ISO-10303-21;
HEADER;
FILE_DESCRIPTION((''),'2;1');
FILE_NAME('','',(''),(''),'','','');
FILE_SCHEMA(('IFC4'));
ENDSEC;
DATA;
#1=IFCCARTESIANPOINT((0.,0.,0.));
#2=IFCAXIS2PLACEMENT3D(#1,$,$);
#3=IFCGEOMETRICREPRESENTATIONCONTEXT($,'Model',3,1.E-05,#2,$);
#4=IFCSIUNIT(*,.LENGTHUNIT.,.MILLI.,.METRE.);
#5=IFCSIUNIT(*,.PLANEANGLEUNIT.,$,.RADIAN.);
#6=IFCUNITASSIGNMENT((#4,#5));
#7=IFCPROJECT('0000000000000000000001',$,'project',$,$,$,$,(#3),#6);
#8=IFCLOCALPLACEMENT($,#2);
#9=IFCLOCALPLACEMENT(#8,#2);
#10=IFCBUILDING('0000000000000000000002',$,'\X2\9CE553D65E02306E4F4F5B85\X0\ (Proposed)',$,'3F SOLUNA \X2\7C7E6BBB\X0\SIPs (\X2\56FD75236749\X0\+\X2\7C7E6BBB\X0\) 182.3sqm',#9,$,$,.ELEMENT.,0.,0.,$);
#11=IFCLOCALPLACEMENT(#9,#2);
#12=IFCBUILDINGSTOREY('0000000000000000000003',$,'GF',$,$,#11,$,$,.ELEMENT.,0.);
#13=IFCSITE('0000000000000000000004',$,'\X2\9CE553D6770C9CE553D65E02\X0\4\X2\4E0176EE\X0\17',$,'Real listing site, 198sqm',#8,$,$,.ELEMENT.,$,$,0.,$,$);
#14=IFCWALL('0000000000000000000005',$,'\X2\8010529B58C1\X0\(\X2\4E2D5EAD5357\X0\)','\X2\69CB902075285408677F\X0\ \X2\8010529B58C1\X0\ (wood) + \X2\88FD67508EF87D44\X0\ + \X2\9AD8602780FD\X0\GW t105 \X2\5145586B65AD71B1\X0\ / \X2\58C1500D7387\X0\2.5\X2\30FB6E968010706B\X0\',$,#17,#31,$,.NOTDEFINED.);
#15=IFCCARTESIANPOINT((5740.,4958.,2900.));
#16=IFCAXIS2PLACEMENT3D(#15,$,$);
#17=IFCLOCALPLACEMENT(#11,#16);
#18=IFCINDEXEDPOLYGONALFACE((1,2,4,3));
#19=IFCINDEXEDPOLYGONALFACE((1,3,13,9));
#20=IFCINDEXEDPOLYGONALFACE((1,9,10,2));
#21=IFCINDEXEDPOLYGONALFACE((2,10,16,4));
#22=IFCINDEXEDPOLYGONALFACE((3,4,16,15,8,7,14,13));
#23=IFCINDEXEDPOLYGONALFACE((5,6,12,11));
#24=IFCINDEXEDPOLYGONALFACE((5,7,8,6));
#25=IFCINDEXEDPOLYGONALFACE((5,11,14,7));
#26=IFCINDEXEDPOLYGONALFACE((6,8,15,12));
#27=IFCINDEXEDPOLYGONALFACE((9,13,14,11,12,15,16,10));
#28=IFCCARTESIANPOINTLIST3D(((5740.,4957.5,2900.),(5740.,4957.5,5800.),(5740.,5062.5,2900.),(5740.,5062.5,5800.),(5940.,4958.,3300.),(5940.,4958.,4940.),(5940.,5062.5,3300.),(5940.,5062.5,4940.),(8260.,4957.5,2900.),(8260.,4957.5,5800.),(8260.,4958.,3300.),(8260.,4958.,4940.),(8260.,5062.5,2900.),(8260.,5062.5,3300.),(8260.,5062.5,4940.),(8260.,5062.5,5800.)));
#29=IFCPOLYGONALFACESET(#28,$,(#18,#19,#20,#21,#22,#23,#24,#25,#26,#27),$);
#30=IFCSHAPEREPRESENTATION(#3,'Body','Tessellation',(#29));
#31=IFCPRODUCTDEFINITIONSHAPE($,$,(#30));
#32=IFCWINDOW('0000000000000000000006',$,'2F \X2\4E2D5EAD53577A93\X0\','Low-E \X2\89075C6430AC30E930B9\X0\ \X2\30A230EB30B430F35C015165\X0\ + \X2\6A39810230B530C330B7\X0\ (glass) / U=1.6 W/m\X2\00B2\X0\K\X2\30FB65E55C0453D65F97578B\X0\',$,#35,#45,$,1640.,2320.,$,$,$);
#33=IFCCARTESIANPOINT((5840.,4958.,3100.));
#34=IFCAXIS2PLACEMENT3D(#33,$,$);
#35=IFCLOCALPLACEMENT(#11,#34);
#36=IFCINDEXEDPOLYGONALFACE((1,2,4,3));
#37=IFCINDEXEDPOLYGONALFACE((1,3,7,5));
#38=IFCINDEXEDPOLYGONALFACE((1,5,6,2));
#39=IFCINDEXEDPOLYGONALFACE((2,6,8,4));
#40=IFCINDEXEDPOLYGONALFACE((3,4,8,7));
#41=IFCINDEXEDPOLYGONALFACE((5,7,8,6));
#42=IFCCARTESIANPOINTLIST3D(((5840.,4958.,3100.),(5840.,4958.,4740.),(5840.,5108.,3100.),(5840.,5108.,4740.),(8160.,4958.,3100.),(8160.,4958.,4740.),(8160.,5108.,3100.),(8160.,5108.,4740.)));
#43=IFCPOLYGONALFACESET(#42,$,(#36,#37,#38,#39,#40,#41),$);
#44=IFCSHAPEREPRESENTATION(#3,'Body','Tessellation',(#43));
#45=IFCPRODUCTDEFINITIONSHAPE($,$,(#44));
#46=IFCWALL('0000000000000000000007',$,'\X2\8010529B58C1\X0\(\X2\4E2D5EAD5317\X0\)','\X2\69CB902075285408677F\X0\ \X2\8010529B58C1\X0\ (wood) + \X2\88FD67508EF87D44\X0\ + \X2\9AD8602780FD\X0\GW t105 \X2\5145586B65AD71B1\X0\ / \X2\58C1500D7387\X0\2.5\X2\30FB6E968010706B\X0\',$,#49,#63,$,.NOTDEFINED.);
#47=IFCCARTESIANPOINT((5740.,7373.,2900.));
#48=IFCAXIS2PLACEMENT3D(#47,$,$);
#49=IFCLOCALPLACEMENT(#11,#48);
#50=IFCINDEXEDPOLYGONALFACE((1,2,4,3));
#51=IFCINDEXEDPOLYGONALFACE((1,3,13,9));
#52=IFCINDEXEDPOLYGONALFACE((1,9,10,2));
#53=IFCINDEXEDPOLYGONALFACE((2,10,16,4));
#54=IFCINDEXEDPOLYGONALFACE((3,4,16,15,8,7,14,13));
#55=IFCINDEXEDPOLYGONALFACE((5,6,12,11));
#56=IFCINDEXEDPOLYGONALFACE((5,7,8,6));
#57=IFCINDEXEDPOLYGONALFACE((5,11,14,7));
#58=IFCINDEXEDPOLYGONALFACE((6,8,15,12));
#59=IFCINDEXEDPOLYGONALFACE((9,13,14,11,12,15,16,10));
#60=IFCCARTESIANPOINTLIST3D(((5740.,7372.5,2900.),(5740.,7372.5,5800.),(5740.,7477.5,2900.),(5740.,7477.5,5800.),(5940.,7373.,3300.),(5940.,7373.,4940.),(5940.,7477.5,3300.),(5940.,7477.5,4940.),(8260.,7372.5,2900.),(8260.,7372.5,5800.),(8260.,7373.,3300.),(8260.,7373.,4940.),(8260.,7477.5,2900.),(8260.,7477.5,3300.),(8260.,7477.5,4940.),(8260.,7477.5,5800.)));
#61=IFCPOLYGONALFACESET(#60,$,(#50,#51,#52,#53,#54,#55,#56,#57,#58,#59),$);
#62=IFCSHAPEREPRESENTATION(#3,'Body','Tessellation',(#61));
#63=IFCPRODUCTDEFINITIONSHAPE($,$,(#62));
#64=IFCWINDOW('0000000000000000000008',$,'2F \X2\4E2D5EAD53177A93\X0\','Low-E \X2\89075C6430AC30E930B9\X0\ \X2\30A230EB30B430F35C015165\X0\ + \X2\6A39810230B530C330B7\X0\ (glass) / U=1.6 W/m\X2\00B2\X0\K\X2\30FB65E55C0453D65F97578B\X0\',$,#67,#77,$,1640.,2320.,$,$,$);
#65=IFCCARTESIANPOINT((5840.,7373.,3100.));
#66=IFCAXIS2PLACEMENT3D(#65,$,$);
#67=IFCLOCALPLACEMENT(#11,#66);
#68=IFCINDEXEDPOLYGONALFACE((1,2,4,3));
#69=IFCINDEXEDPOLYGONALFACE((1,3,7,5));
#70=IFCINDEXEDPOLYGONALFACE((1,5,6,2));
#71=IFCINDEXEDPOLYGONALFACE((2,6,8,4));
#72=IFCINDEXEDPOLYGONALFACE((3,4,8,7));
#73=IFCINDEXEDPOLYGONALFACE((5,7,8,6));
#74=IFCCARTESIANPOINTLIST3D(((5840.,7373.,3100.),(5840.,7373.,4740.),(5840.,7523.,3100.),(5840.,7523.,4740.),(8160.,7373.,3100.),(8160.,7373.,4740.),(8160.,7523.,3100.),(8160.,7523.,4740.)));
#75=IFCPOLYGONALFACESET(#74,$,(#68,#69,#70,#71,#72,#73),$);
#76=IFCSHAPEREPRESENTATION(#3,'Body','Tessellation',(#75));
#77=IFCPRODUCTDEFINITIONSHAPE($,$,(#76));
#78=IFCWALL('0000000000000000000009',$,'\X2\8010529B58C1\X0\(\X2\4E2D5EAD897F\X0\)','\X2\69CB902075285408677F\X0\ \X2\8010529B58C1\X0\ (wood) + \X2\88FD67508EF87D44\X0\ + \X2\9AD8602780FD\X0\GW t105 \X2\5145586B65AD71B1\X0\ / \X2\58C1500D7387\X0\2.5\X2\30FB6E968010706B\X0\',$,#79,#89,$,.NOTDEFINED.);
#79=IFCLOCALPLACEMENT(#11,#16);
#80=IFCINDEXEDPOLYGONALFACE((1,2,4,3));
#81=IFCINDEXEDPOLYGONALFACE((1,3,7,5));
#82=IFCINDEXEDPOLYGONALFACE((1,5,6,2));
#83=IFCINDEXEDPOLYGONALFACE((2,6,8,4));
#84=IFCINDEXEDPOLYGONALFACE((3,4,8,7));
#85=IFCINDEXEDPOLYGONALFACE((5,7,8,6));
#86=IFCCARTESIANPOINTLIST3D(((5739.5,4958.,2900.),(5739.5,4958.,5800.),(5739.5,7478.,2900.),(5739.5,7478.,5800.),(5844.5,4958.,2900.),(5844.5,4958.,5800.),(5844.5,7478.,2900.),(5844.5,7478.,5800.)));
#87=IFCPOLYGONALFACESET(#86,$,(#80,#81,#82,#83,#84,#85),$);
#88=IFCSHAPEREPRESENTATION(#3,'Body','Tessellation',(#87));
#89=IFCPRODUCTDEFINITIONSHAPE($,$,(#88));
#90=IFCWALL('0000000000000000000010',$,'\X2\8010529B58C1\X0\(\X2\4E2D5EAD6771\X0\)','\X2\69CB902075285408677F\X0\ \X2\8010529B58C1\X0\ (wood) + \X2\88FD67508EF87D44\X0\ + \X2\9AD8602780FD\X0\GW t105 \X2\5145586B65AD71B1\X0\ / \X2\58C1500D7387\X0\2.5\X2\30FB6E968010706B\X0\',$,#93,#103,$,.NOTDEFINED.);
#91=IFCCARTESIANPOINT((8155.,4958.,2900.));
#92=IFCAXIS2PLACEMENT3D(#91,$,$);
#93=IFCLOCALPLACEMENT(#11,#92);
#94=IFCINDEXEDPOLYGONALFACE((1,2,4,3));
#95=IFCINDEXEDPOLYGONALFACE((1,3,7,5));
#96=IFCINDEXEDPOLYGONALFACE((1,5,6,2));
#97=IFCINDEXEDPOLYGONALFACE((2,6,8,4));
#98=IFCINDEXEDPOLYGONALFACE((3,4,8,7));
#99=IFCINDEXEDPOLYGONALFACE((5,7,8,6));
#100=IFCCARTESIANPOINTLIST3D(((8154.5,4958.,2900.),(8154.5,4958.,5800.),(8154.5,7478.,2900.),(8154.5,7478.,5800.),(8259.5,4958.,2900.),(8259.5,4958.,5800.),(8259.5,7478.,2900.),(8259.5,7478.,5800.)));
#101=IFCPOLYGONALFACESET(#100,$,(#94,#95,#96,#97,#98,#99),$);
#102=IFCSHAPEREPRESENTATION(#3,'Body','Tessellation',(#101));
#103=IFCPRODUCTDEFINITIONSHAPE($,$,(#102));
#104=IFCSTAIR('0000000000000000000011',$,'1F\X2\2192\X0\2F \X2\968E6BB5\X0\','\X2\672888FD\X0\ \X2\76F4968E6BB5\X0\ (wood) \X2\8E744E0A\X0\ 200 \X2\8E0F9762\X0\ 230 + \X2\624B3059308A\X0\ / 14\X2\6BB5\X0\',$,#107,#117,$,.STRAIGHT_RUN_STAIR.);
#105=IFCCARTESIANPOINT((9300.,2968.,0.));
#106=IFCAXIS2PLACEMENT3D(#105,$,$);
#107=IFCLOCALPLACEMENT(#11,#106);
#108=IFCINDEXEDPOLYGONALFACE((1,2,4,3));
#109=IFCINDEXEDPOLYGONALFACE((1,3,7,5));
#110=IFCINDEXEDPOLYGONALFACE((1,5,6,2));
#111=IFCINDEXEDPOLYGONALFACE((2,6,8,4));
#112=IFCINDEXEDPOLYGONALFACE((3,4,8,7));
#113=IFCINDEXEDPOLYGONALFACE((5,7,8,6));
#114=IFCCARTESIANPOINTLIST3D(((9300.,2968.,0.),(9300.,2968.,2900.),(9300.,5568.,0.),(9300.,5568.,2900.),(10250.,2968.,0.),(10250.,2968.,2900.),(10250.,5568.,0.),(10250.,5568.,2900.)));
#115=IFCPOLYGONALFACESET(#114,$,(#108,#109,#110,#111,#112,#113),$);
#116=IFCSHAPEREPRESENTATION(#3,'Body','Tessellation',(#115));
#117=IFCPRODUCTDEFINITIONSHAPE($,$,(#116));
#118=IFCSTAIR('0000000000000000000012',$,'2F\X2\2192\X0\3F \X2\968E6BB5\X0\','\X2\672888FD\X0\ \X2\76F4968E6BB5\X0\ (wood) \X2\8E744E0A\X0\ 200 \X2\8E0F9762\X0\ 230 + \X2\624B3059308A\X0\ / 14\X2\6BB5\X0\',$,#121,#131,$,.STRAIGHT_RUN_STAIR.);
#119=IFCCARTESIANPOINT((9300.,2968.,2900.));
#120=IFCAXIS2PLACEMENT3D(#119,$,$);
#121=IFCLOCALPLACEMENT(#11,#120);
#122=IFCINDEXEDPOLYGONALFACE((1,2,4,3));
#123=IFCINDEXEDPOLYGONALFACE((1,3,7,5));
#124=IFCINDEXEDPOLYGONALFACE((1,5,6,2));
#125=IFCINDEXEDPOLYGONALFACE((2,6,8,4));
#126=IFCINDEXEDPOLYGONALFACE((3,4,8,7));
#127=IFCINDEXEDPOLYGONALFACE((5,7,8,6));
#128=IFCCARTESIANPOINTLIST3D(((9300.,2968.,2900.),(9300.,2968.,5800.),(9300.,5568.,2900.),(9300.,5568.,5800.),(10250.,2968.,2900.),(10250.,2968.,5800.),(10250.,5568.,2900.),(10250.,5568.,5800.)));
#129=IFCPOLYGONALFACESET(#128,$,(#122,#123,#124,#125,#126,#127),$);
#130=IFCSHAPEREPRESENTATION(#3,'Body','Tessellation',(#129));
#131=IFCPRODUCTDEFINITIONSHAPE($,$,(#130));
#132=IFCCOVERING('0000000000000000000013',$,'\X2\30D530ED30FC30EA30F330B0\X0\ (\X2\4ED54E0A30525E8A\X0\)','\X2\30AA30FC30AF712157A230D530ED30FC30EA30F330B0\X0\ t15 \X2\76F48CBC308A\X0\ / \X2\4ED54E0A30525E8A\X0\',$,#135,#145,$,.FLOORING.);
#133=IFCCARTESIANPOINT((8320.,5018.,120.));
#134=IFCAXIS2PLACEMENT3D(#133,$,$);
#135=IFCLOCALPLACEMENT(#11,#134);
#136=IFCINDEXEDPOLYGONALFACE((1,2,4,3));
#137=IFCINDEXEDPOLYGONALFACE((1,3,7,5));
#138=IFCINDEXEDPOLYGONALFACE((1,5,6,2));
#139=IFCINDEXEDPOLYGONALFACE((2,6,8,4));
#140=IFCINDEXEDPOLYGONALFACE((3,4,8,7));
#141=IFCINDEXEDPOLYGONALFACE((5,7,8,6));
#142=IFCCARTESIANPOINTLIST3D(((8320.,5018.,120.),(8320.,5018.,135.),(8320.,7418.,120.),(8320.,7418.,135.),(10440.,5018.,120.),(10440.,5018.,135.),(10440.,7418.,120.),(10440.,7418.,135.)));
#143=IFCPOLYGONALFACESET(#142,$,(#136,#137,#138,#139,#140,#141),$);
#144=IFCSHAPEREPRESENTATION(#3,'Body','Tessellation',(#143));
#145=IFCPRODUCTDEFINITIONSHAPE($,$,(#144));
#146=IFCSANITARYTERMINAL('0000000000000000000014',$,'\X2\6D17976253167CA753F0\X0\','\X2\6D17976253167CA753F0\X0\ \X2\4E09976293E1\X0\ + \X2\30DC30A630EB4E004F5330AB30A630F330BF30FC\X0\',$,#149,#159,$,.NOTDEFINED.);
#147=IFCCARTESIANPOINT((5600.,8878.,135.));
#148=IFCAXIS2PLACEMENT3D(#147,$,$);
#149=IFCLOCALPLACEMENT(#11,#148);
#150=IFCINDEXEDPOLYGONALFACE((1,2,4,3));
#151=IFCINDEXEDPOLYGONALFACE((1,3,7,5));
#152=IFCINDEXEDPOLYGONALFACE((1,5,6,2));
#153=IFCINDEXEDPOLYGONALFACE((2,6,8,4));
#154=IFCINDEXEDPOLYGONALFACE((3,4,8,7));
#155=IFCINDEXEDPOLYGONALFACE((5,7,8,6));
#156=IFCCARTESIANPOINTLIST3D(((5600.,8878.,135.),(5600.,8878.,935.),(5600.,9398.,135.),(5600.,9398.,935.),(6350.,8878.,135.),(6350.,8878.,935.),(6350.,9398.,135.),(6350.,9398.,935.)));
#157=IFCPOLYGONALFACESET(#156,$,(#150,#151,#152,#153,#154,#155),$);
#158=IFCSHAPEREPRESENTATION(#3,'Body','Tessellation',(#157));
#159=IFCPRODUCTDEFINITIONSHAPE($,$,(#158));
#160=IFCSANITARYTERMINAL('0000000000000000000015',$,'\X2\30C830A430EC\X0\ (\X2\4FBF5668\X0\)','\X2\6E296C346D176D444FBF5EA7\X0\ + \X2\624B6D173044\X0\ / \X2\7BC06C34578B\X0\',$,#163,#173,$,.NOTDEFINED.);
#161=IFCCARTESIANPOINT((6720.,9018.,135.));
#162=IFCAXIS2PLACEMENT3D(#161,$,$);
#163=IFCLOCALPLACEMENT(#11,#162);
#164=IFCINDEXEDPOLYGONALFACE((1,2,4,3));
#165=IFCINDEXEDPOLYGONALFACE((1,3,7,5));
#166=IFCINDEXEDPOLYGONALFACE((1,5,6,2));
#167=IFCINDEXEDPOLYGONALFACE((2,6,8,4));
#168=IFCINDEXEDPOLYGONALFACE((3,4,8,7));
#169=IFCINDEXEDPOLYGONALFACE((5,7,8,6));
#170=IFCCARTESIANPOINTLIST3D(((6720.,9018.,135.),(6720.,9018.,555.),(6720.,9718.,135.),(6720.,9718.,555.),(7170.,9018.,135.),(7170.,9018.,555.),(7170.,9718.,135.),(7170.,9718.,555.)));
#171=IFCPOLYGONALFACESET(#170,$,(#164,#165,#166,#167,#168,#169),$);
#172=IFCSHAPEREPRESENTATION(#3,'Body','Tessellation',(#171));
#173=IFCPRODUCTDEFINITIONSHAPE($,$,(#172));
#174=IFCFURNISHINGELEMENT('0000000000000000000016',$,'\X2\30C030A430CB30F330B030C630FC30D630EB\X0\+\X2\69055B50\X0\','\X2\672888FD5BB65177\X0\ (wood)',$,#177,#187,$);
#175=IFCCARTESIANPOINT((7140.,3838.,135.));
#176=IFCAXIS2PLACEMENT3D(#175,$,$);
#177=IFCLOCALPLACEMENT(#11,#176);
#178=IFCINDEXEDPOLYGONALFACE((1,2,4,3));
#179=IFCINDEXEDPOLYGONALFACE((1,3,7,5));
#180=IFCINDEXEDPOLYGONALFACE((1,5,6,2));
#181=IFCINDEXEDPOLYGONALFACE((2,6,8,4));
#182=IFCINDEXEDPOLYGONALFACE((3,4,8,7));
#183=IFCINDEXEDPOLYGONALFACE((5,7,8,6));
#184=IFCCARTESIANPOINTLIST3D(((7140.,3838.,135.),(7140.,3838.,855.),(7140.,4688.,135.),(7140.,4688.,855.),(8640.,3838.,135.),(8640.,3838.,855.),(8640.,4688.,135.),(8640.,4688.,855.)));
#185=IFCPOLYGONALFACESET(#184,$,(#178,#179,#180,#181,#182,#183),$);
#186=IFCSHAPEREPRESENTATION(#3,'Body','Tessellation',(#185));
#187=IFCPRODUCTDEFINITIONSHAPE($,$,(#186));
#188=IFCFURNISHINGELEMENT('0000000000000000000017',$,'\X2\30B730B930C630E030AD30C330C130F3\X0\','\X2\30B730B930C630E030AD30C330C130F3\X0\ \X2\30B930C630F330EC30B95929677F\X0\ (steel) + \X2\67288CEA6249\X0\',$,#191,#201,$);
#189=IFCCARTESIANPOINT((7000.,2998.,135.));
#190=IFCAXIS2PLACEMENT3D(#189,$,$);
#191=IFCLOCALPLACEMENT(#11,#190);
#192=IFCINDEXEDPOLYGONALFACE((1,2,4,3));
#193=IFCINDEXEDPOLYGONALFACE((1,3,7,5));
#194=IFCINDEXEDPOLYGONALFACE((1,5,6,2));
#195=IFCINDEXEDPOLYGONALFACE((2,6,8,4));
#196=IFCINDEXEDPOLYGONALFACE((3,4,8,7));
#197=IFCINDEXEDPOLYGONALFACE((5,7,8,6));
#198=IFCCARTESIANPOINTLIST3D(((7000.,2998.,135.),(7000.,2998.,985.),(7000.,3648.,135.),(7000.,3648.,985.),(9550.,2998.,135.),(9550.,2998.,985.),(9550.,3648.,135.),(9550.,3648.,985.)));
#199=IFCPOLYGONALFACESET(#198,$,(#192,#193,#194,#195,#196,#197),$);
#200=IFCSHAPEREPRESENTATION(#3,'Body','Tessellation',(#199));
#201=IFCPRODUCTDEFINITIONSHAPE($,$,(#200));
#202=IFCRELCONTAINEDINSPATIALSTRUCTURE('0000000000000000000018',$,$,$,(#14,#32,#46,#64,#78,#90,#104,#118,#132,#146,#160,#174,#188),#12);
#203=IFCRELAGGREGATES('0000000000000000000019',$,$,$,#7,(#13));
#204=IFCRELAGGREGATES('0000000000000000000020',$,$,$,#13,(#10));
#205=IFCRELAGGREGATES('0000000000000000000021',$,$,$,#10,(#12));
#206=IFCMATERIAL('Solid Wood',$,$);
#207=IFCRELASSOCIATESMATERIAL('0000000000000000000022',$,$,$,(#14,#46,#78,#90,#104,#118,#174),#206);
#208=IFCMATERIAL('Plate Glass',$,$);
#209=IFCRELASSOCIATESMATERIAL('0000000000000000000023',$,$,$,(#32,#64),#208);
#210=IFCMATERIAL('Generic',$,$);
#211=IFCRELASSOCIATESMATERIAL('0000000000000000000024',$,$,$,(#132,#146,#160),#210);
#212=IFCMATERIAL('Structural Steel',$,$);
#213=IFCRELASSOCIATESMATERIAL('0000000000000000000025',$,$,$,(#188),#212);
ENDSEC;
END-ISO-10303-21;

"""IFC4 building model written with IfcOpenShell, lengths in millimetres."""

from ifc_helpers import new_model, si_unit, frame, frame_2d, origin, place, context, project, spatial, rectangle, extrude, material, element, fill, save


model = new_model("IFC4")

# Units and contexts
model_context = context("Model", 3, precision=1e-05, world=origin())
ifc_project = project(units=[si_unit("LENGTHUNIT", "METRE", prefix="MILLI"), si_unit("PLANEANGLEUNIT", "RADIAN")], contexts=[model_context])

# Site, building, storey
site_placement = place(None, origin())
site = spatial("IfcSite", under=ifc_project, at=site_placement, Name="鳥取県鳥取市4丁目17", ObjectType="Real listing site, 198sqm", CompositionType="ELEMENT", RefElevation=0.0)
building_placement = place(site_placement, origin())
building = spatial("IfcBuilding", under=site, at=building_placement, Name="鳥取市の住宅 (Proposed)", ObjectType="3F SOLUNA 籾殻SIPs (国産杉+籾殻) 182.3sqm", CompositionType="ELEMENT", ElevationOfRefHeight=0.0, ElevationOfTerrain=0.0)
storey_placement = place(building_placement, origin())
storey = spatial("IfcBuildingStorey", under=building, at=storey_placement, Name="GF", CompositionType="ELEMENT", Elevation=0.0)

# Shared definitions
ifc_material_1 = material(Name="Solid Wood")

# Shared definitions
ifc_material_2 = material(Name="Plate Glass")

# Walls, openings, windows
wall_1_placement = place(storey_placement, frame((5740.0, 4958.0, 2900.0)))
wall_1 = element("IfcWall", 1, at=wall_1_placement, inside=storey, material=ifc_material_1, Name="耐力壁(中庭南)", Description="構造用合板 耐力壁 (wood) + 製材軸組 + 高性能GW t105 充填断熱 / 壁倍率2.5・準耐火", PredefinedType="NOTDEFINED", context=model_context, shape_type="SweptSolid", body=[
    extrude(rectangle(XDim=2520.0, YDim=105.0, at=frame_2d((1260.0, 52.0))), frame((5740.0, 4958.0, 2900.0)), (0.0, 0.0, 1.0), 2900.0),
])
opening_1_placement = place(storey_placement, frame((5840.0, 4958.0, 3100.0)))
opening_1 = element("IfcOpeningElement", 2, at=opening_1_placement, cuts=wall_1, PredefinedType="NOTDEFINED", context=model_context, shape_type="SweptSolid", body=[
    extrude(rectangle(XDim=2320.0, YDim=150.0, at=frame_2d((1160.0, 75.0))), frame((5840.0, 4958.0, 3100.0)), (0.0, 0.0, 1.0), 1640.0),
])
window_1_placement = place(storey_placement, frame((5840.0, 4958.0, 3100.0)))
window_1 = element("IfcWindow", 3, at=window_1_placement, inside=storey, material=ifc_material_2, Name="2F 中庭南窓", Description="Low-E 複層ガラス アルゴン封入 + 樹脂サッシ (glass) / U=1.6 W/m²K・日射取得型", OverallHeight=1640.0, OverallWidth=2320.0, context=model_context, shape_type="SweptSolid", body=[
    extrude(rectangle(XDim=2320.0, YDim=150.0, at=frame_2d((1160.0, 75.0))), frame((5840.0, 4958.0, 3100.0)), (0.0, 0.0, 1.0), 1640.0),
])
fill(opening_1, window_1)
wall_2_placement = place(storey_placement, frame((5740.0, 7373.0, 2900.0)))
wall_2 = element("IfcWall", 4, at=wall_2_placement, inside=storey, material=ifc_material_1, Name="耐力壁(中庭北)", Description="構造用合板 耐力壁 (wood) + 製材軸組 + 高性能GW t105 充填断熱 / 壁倍率2.5・準耐火", PredefinedType="NOTDEFINED", context=model_context, shape_type="SweptSolid", body=[
    extrude(rectangle(XDim=2520.0, YDim=105.0, at=frame_2d((1260.0, 52.0))), frame((5740.0, 7373.0, 2900.0)), (0.0, 0.0, 1.0), 2900.0),
])
opening_2_placement = place(storey_placement, frame((5840.0, 7373.0, 3100.0)))
opening_2 = element("IfcOpeningElement", 5, at=opening_2_placement, cuts=wall_2, PredefinedType="NOTDEFINED", context=model_context, shape_type="SweptSolid", body=[
    extrude(rectangle(XDim=2320.0, YDim=150.0, at=frame_2d((1160.0, 75.0))), frame((5840.0, 7373.0, 3100.0)), (0.0, 0.0, 1.0), 1640.0),
])
window_2_placement = place(storey_placement, frame((5840.0, 7373.0, 3100.0)))
window_2 = element("IfcWindow", 6, at=window_2_placement, inside=storey, material=ifc_material_2, Name="2F 中庭北窓", Description="Low-E 複層ガラス アルゴン封入 + 樹脂サッシ (glass) / U=1.6 W/m²K・日射取得型", OverallHeight=1640.0, OverallWidth=2320.0, context=model_context, shape_type="SweptSolid", body=[
    extrude(rectangle(XDim=2320.0, YDim=150.0, at=frame_2d((1160.0, 75.0))), frame((5840.0, 7373.0, 3100.0)), (0.0, 0.0, 1.0), 1640.0),
])
fill(opening_2, window_2)

# Walls
wall_3_placement = place(storey_placement, frame((5740.0, 4958.0, 2900.0)))
element("IfcWall", 7, at=wall_3_placement, inside=storey, material=ifc_material_1, Name="耐力壁(中庭西)", Description="構造用合板 耐力壁 (wood) + 製材軸組 + 高性能GW t105 充填断熱 / 壁倍率2.5・準耐火", PredefinedType="NOTDEFINED", context=model_context, shape_type="SweptSolid", body=[
    extrude(rectangle(XDim=105.0, YDim=2520.0, at=frame_2d((52.0, 1260.0))), frame((5740.0, 4958.0, 2900.0)), (0.0, 0.0, 1.0), 2900.0),
])
wall_4_placement = place(storey_placement, frame((8155.0, 4958.0, 2900.0)))
element("IfcWall", 8, at=wall_4_placement, inside=storey, material=ifc_material_1, Name="耐力壁(中庭東)", Description="構造用合板 耐力壁 (wood) + 製材軸組 + 高性能GW t105 充填断熱 / 壁倍率2.5・準耐火", PredefinedType="NOTDEFINED", context=model_context, shape_type="SweptSolid", body=[
    extrude(rectangle(XDim=105.0, YDim=2520.0, at=frame_2d((52.0, 1260.0))), frame((8155.0, 4958.0, 2900.0)), (0.0, 0.0, 1.0), 2900.0),
])

# Stairs
stair_1_placement = place(storey_placement, frame((9300.0, 2968.0, 0.0)))
element("IfcStair", 9, at=stair_1_placement, inside=storey, material=ifc_material_1, Name="1F→2F 階段", Description="木製 直階段 (wood) 蹴上 200 踏面 230 + 手すり / 14段", PredefinedType="STRAIGHT_RUN_STAIR", context=model_context, shape_type="SweptSolid", body=[
    extrude(rectangle(XDim=950.0, YDim=2600.0, at=frame_2d((475.0, 1300.0))), frame((9300.0, 2968.0, 0.0)), (0.0, 0.0, 1.0), 2900.0),
])
stair_2_placement = place(storey_placement, frame((9300.0, 2968.0, 2900.0)))
element("IfcStair", 10, at=stair_2_placement, inside=storey, material=ifc_material_1, Name="2F→3F 階段", Description="木製 直階段 (wood) 蹴上 200 踏面 230 + 手すり / 14段", PredefinedType="STRAIGHT_RUN_STAIR", context=model_context, shape_type="SweptSolid", body=[
    extrude(rectangle(XDim=950.0, YDim=2600.0, at=frame_2d((475.0, 1300.0))), frame((9300.0, 2968.0, 2900.0)), (0.0, 0.0, 1.0), 2900.0),
])

# Covering
ifc_material_3 = material(Name="Generic")
covering_placement = place(storey_placement, frame((8320.0, 5018.0, 120.0)))
element("IfcCovering", 11, at=covering_placement, inside=storey, material=ifc_material_3, Name="フローリング (仕上げ床)", Description="オーク無垢フローリング t15 直貼り / 仕上げ床", PredefinedType="FLOORING", context=model_context, shape_type="SweptSolid", body=[
    extrude(rectangle(XDim=2120.0, YDim=2400.0, at=frame_2d((1060.0, 1200.0))), frame((8320.0, 5018.0, 120.0)), (0.0, 0.0, 1.0), 15.0),
])

# Sanitary terminals
sanitary_terminal_1_placement = place(storey_placement, frame((5600.0, 8878.0, 135.0)))
element("IfcSanitaryTerminal", 12, at=sanitary_terminal_1_placement, inside=storey, material=ifc_material_3, Name="洗面化粧台", Description="洗面化粧台 三面鏡 + ボウル一体カウンター", PredefinedType="NOTDEFINED", context=model_context, shape_type="SweptSolid", body=[
    extrude(rectangle(XDim=750.0, YDim=520.0, at=frame_2d((375.0, 260.0))), frame((5600.0, 8878.0, 135.0)), (0.0, 0.0, 1.0), 800.0),
])
sanitary_terminal_2_placement = place(storey_placement, frame((6720.0, 9018.0, 135.0)))
element("IfcSanitaryTerminal", 13, at=sanitary_terminal_2_placement, inside=storey, material=ifc_material_3, Name="トイレ (便器)", Description="温水洗浄便座 + 手洗い / 節水型", PredefinedType="NOTDEFINED", context=model_context, shape_type="SweptSolid", body=[
    extrude(rectangle(XDim=450.0, YDim=700.0, at=frame_2d((225.0, 350.0))), frame((6720.0, 9018.0, 135.0)), (0.0, 0.0, 1.0), 420.0),
])

# Furnishing elements
furnishing_1_placement = place(storey_placement, frame((7140.0, 3838.0, 135.0)))
element("IfcFurnishingElement", 14, at=furnishing_1_placement, inside=storey, material=ifc_material_1, Name="ダイニングテーブル+椅子", Description="木製家具 (wood)", context=model_context, shape_type="SweptSolid", body=[
    extrude(rectangle(XDim=1500.0, YDim=850.0, at=frame_2d((750.0, 425.0))), frame((7140.0, 3838.0, 135.0)), (0.0, 0.0, 1.0), 720.0),
])
ifc_material_4 = material(Name="Structural Steel")
furnishing_2_placement = place(storey_placement, frame((7000.0, 2998.0, 135.0)))
element("IfcFurnishingElement", 15, at=furnishing_2_placement, inside=storey, material=ifc_material_4, Name="システムキッチン", Description="システムキッチン ステンレス天板 (steel) + 木質扉", context=model_context, shape_type="SweptSolid", body=[
    extrude(rectangle(XDim=2550.0, YDim=650.0, at=frame_2d((1275.0, 325.0))), frame((7000.0, 2998.0, 135.0)), (0.0, 0.0, 1.0), 850.0),
])

save(model, "model.ifc")
